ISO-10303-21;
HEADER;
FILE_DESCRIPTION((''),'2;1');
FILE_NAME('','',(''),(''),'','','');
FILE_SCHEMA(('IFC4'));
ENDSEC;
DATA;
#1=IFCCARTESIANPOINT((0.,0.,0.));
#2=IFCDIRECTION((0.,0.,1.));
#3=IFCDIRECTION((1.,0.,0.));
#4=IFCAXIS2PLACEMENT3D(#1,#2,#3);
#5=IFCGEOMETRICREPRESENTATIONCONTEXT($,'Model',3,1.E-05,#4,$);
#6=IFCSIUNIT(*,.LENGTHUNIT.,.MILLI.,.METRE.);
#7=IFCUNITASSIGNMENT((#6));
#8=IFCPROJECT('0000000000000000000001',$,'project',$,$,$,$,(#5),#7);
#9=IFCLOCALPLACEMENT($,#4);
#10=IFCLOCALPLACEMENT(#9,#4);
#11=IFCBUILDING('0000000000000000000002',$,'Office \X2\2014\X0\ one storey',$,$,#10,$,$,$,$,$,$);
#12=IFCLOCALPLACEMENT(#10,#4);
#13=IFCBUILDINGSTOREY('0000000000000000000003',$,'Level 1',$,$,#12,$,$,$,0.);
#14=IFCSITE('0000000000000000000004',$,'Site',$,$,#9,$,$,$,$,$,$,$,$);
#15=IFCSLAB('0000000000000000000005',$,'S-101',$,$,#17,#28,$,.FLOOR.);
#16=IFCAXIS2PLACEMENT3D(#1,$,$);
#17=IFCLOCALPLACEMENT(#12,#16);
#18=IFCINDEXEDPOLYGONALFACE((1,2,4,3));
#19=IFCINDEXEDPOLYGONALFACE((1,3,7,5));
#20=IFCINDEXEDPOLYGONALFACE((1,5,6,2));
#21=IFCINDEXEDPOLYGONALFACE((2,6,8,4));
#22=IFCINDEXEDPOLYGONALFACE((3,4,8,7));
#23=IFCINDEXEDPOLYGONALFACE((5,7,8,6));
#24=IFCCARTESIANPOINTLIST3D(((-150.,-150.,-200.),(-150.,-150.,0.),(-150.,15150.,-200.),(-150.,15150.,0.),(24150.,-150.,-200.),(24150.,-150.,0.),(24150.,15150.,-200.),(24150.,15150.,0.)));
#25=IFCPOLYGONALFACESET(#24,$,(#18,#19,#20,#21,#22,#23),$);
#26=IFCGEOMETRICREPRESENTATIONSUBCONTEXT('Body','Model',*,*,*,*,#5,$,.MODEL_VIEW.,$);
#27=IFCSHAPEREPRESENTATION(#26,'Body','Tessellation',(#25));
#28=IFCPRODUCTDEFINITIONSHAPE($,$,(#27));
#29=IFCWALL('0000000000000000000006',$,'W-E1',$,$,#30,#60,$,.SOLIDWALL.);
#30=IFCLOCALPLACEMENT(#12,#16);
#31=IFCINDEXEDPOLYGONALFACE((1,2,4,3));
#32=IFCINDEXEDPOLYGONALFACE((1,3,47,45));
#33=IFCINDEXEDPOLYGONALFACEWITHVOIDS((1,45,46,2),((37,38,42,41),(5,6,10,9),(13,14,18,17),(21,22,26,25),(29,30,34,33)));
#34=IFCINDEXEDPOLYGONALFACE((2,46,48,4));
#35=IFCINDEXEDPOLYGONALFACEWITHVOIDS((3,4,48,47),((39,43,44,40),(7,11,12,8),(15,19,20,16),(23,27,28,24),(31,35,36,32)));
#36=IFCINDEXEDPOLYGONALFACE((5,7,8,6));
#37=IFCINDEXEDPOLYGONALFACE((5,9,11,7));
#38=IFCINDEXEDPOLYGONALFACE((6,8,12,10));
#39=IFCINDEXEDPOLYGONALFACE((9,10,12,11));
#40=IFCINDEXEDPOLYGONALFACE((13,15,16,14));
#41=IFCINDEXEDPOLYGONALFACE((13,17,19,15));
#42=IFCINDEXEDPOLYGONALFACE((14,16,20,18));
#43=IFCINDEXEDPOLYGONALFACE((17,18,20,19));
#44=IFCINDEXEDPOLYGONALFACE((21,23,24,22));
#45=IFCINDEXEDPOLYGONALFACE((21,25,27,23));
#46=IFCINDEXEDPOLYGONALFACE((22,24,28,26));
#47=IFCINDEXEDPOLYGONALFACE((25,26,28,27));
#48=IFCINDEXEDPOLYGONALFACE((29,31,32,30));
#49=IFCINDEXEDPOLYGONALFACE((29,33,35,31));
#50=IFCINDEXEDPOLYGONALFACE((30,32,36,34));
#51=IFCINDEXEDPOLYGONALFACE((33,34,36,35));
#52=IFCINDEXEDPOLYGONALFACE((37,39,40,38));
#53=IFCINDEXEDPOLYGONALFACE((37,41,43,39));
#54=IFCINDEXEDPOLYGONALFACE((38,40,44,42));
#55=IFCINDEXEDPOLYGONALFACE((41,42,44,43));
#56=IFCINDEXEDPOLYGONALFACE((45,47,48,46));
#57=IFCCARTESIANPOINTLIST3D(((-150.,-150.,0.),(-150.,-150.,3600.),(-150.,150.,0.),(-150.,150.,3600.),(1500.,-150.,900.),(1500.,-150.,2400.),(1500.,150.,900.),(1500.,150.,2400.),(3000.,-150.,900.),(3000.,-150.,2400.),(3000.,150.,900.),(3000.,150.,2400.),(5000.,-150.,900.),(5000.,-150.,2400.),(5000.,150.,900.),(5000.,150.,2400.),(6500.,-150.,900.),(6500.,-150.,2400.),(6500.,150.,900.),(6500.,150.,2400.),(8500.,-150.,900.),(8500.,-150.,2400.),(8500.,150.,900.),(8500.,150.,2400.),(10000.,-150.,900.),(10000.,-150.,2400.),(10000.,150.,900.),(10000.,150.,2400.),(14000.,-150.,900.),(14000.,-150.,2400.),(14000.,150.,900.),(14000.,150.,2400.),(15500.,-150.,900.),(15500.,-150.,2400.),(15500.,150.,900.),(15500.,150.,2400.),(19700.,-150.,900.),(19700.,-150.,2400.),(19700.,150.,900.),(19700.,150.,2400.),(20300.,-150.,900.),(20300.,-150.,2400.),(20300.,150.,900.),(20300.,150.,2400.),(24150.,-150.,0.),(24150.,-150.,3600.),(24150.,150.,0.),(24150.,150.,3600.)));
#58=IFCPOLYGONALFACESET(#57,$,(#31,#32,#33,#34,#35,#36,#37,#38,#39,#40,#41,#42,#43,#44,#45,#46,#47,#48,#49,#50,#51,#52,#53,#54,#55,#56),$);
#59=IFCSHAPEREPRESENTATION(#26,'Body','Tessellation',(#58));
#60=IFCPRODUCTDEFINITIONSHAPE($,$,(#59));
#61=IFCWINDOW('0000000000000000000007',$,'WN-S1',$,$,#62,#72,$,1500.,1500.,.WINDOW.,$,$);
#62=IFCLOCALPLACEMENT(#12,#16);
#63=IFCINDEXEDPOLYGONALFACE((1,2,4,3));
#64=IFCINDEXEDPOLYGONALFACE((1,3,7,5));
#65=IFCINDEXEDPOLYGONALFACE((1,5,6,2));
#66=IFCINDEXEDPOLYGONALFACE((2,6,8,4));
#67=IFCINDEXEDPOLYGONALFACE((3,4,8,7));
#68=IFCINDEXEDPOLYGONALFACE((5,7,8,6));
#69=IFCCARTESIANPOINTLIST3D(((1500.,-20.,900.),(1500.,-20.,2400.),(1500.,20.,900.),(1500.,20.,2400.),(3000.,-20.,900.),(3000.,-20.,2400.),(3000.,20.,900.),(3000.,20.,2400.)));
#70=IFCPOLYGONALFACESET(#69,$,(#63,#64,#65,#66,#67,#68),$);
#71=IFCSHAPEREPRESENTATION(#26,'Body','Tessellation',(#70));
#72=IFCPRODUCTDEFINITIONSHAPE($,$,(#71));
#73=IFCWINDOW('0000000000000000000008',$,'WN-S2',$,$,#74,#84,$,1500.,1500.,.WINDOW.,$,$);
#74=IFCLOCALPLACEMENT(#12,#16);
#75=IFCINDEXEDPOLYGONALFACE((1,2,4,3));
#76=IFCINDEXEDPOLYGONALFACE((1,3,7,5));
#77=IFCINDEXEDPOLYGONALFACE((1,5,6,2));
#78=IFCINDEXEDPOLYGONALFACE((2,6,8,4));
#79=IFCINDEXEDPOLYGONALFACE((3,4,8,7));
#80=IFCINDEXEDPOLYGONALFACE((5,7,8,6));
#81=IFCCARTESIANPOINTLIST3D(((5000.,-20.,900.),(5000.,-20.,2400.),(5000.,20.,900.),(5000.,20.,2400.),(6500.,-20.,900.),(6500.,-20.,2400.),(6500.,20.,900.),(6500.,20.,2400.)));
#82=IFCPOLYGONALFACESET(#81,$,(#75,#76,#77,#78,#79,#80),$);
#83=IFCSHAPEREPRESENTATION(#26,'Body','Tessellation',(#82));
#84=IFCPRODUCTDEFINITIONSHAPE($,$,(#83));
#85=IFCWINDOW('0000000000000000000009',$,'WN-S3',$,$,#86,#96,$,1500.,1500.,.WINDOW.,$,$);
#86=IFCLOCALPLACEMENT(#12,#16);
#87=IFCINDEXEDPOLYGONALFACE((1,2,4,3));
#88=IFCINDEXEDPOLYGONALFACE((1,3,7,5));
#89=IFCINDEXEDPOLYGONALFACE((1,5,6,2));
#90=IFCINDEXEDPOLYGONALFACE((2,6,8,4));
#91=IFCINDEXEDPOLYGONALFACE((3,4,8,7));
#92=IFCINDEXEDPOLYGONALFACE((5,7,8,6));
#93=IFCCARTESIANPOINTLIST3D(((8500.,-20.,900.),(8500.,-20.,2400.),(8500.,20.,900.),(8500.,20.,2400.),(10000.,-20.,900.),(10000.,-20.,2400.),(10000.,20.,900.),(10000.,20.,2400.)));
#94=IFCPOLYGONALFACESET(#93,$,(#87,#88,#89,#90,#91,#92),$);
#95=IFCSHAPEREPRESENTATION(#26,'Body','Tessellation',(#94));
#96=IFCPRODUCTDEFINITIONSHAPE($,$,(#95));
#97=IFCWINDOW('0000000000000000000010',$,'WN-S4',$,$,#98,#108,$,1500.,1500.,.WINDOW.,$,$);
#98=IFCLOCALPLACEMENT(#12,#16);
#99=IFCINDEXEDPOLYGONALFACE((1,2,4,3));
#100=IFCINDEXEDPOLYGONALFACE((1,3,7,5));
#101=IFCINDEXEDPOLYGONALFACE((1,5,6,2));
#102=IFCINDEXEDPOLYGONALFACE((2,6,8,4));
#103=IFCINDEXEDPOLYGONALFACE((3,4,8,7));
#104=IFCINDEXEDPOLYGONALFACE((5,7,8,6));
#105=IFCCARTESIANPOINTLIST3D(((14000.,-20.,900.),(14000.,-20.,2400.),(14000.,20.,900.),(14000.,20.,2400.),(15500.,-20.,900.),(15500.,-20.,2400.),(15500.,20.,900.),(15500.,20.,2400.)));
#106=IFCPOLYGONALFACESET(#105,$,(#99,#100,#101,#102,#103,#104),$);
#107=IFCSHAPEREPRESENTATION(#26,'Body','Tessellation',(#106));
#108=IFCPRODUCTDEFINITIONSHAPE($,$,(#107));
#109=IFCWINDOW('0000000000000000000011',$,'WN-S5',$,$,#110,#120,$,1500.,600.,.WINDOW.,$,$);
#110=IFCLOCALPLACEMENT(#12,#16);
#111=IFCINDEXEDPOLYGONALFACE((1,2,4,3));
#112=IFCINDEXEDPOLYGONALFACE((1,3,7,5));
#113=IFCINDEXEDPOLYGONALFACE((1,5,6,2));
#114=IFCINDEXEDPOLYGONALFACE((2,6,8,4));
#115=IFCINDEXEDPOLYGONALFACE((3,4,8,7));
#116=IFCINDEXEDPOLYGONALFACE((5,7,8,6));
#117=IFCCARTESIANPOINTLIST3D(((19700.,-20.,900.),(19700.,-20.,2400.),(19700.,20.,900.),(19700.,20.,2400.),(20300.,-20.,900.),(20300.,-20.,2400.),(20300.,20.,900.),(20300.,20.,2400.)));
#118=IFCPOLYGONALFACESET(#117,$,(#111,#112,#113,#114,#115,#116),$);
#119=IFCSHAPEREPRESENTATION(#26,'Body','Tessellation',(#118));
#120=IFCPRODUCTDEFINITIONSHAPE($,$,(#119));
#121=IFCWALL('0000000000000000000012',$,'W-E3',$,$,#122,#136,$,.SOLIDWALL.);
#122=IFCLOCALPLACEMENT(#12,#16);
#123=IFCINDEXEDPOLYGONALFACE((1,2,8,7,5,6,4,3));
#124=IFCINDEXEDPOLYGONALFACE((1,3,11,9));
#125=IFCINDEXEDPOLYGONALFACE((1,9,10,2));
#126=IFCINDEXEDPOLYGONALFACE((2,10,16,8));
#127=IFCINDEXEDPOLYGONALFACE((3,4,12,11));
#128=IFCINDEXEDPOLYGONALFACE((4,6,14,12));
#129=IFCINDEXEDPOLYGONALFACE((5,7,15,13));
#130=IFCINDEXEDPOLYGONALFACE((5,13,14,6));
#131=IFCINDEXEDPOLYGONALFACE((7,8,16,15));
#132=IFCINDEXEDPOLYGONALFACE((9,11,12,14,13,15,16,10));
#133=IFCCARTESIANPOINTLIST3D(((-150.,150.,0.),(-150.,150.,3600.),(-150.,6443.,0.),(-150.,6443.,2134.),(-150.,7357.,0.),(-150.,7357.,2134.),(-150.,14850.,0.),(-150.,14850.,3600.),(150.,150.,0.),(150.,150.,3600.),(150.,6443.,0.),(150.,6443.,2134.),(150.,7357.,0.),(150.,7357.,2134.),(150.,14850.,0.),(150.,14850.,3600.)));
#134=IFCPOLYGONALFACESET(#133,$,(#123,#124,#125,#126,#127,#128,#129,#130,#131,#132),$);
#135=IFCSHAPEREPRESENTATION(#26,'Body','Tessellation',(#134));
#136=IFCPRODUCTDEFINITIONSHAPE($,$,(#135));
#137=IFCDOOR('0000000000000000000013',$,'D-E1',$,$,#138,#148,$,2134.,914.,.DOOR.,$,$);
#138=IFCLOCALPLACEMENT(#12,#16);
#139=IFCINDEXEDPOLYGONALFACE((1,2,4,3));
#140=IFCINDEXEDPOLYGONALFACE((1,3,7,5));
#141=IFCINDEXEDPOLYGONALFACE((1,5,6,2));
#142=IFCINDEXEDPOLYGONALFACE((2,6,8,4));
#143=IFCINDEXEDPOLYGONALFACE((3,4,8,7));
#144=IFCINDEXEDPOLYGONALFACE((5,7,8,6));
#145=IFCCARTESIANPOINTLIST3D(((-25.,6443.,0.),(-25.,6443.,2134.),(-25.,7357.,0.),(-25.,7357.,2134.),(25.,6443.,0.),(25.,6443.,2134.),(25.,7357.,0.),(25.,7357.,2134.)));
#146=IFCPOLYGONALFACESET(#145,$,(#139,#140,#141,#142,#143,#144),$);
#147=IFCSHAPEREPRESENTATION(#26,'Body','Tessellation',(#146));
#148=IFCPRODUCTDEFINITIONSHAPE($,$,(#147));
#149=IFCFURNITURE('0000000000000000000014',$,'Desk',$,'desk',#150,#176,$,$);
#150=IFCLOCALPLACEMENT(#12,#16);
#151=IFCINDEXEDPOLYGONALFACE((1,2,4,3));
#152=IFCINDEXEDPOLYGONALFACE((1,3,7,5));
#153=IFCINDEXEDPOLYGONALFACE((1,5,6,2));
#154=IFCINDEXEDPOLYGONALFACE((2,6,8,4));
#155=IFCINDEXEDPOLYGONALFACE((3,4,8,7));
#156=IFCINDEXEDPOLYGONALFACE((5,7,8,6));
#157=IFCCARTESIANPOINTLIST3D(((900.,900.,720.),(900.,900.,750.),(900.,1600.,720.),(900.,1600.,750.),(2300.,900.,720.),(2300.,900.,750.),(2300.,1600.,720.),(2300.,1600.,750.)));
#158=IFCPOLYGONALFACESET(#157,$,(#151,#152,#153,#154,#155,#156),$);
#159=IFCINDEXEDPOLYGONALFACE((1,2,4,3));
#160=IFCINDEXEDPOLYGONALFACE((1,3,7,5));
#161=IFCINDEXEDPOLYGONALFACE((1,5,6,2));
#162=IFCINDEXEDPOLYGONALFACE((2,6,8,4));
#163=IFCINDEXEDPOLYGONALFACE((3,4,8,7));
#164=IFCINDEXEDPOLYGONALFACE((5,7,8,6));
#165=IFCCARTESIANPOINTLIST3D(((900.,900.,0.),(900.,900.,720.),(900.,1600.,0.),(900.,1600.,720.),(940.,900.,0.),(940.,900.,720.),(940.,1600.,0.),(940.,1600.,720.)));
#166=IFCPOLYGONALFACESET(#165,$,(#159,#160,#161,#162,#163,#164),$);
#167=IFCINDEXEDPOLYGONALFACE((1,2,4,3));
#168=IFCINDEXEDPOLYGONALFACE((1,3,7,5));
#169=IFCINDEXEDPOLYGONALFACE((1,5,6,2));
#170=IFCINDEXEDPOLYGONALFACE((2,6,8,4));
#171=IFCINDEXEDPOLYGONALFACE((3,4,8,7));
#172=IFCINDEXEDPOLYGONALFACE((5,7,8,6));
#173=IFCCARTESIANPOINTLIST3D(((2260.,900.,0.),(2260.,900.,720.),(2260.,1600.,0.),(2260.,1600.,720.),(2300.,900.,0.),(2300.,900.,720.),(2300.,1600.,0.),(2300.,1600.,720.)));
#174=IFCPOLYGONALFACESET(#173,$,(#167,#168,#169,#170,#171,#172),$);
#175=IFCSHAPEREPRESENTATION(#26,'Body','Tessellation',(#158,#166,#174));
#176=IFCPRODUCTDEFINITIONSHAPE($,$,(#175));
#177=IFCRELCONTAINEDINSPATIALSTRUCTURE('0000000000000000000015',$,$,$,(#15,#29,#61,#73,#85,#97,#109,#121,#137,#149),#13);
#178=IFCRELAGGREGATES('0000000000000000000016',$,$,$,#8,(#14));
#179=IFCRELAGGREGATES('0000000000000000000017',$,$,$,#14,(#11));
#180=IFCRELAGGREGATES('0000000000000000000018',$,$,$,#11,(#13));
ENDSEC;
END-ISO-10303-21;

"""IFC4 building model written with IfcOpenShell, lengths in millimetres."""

from ifc_helpers import new_model, si_unit, frame, frame_2d, origin, origin_with_axes, place, context, subcontext, project, spatial, rectangle, extrude, element, fill, save


model = new_model("IFC4")

# Units and contexts
model_context = context("Model", 3, precision=1e-05, world=origin_with_axes())
body_context = subcontext(model_context, "Body", "Model", "MODEL_VIEW")
ifc_project = project(units=[si_unit("LENGTHUNIT", "METRE", prefix="MILLI")], contexts=[model_context])

# Site, building, storey
site_placement = place(None, origin_with_axes())
site = spatial("IfcSite", under=ifc_project, at=site_placement, Name="Site")
building_placement = place(site_placement, origin_with_axes())
building = spatial("IfcBuilding", under=site, at=building_placement, Name="Office — one storey")
storey_placement = place(building_placement, origin_with_axes())
storey = spatial("IfcBuildingStorey", under=building, at=storey_placement, Name="Level 1", Elevation=0.0)

# Slab
slab_placement = place(storey_placement, frame((-150.0, -150.0, -200.0), z_axis=(0.0, 0.0, 1.0), x_axis=(1.0, 0.0, 0.0)))
element("IfcSlab", 1, at=slab_placement, inside=storey, Name="S-101", PredefinedType="FLOOR", context=body_context, shape_type="SweptSolid", body=[
    extrude(rectangle(XDim=24300.0, YDim=15300.0, at=frame_2d((12150.0, 7650.0))), origin(), (0.0, 0.0, 1.0), 200.0),
])

# Wall, openings, windows
wall_1_placement = place(storey_placement, frame((0.0, -150.0, 0.0), z_axis=(0.0, 0.0, 1.0), x_axis=(1.0, 0.0, 0.0)))
wall_1 = element("IfcWall", 2, at=wall_1_placement, inside=storey, Name="W-E1", PredefinedType="SOLIDWALL", context=body_context, shape_type="SweptSolid", body=[
    extrude(rectangle(XDim=24300.0, YDim=300.0, at=frame_2d((12000.0, 150.0))), origin(), (0.0, 0.0, 1.0), 3600.0),
])
opening_1_placement = place(wall_1_placement, frame((1500.0, -10.0, 900.0), z_axis=(0.0, 0.0, 1.0), x_axis=(1.0, 0.0, 0.0)))
opening_1 = element("IfcOpeningElement", 3, at=opening_1_placement, cuts=wall_1, context=body_context, shape_type="SweptSolid", body=[
    extrude(rectangle(XDim=1500.0, YDim=320.0, at=frame_2d((750.0, 160.0))), origin(), (0.0, 0.0, 1.0), 1500.0),
])
opening_2_placement = place(wall_1_placement, frame((5000.0, -10.0, 900.0), z_axis=(0.0, 0.0, 1.0), x_axis=(1.0, 0.0, 0.0)))
opening_2 = element("IfcOpeningElement", 4, at=opening_2_placement, cuts=wall_1, context=body_context, shape_type="SweptSolid", body=[
    extrude(rectangle(XDim=1500.0, YDim=320.0, at=frame_2d((750.0, 160.0))), origin(), (0.0, 0.0, 1.0), 1500.0),
])
opening_3_placement = place(wall_1_placement, frame((8500.0, -10.0, 900.0), z_axis=(0.0, 0.0, 1.0), x_axis=(1.0, 0.0, 0.0)))
opening_3 = element("IfcOpeningElement", 5, at=opening_3_placement, cuts=wall_1, context=body_context, shape_type="SweptSolid", body=[
    extrude(rectangle(XDim=1500.0, YDim=320.0, at=frame_2d((750.0, 160.0))), origin(), (0.0, 0.0, 1.0), 1500.0),
])
opening_4_placement = place(wall_1_placement, frame((14000.0, -10.0, 900.0), z_axis=(0.0, 0.0, 1.0), x_axis=(1.0, 0.0, 0.0)))
opening_4 = element("IfcOpeningElement", 6, at=opening_4_placement, cuts=wall_1, context=body_context, shape_type="SweptSolid", body=[
    extrude(rectangle(XDim=1500.0, YDim=320.0, at=frame_2d((750.0, 160.0))), origin(), (0.0, 0.0, 1.0), 1500.0),
])
opening_5_placement = place(wall_1_placement, frame((19700.0, -10.0, 900.0), z_axis=(0.0, 0.0, 1.0), x_axis=(1.0, 0.0, 0.0)))
opening_5 = element("IfcOpeningElement", 7, at=opening_5_placement, cuts=wall_1, context=body_context, shape_type="SweptSolid", body=[
    extrude(rectangle(XDim=600.0, YDim=320.0, at=frame_2d((300.0, 160.0))), origin(), (0.0, 0.0, 1.0), 1500.0),
])
window_1_placement = place(storey_placement, frame((1500.0, -20.0, 900.0), z_axis=(0.0, 0.0, 1.0), x_axis=(1.0, 0.0, 0.0)))
window_1 = element("IfcWindow", 8, at=window_1_placement, inside=storey, Name="WN-S1", OverallHeight=1500.0, OverallWidth=1500.0, PredefinedType="WINDOW", context=body_context, shape_type="SweptSolid", body=[
    extrude(rectangle(XDim=1500.0, YDim=40.0, at=frame_2d((750.0, 20.0))), origin(), (0.0, 0.0, 1.0), 1500.0),
])
fill(opening_1, window_1)
window_2_placement = place(storey_placement, frame((5000.0, -20.0, 900.0), z_axis=(0.0, 0.0, 1.0), x_axis=(1.0, 0.0, 0.0)))
window_2 = element("IfcWindow", 9, at=window_2_placement, inside=storey, Name="WN-S2", OverallHeight=1500.0, OverallWidth=1500.0, PredefinedType="WINDOW", context=body_context, shape_type="SweptSolid", body=[
    extrude(rectangle(XDim=1500.0, YDim=40.0, at=frame_2d((750.0, 20.0))), origin(), (0.0, 0.0, 1.0), 1500.0),
])
fill(opening_2, window_2)
window_3_placement = place(storey_placement, frame((8500.0, -20.0, 900.0), z_axis=(0.0, 0.0, 1.0), x_axis=(1.0, 0.0, 0.0)))
window_3 = element("IfcWindow", 10, at=window_3_placement, inside=storey, Name="WN-S3", OverallHeight=1500.0, OverallWidth=1500.0, PredefinedType="WINDOW", context=body_context, shape_type="SweptSolid", body=[
    extrude(rectangle(XDim=1500.0, YDim=40.0, at=frame_2d((750.0, 20.0))), origin(), (0.0, 0.0, 1.0), 1500.0),
])
fill(opening_3, window_3)
window_4_placement = place(storey_placement, frame((14000.0, -20.0, 900.0), z_axis=(0.0, 0.0, 1.0), x_axis=(1.0, 0.0, 0.0)))
window_4 = element("IfcWindow", 11, at=window_4_placement, inside=storey, Name="WN-S4", OverallHeight=1500.0, OverallWidth=1500.0, PredefinedType="WINDOW", context=body_context, shape_type="SweptSolid", body=[
    extrude(rectangle(XDim=1500.0, YDim=40.0, at=frame_2d((750.0, 20.0))), origin(), (0.0, 0.0, 1.0), 1500.0),
])
fill(opening_4, window_4)
window_5_placement = place(storey_placement, frame((19700.0, -20.0, 900.0), z_axis=(0.0, 0.0, 1.0), x_axis=(1.0, 0.0, 0.0)))
window_5 = element("IfcWindow", 12, at=window_5_placement, inside=storey, Name="WN-S5", OverallHeight=1500.0, OverallWidth=600.0, PredefinedType="WINDOW", context=body_context, shape_type="SweptSolid", body=[
    extrude(rectangle(XDim=600.0, YDim=40.0, at=frame_2d((300.0, 20.0))), origin(), (0.0, 0.0, 1.0), 1500.0),
])
fill(opening_5, window_5)

# Wall, opening, door
wall_2_placement = place(storey_placement, frame((-150.0, 0.0, 0.0), z_axis=(0.0, 0.0, 1.0), x_axis=(1.0, 0.0, 0.0)))
wall_2 = element("IfcWall", 13, at=wall_2_placement, inside=storey, Name="W-E3", PredefinedType="SOLIDWALL", context=body_context, shape_type="SweptSolid", body=[
    extrude(rectangle(XDim=300.0, YDim=14700.0, at=frame_2d((150.0, 7500.0))), origin(), (0.0, 0.0, 1.0), 3600.0),
])
opening_6_placement = place(wall_2_placement, frame((-10.0, 6443.0, 0.0), z_axis=(0.0, 0.0, 1.0), x_axis=(1.0, 0.0, 0.0)))
opening_6 = element("IfcOpeningElement", 14, at=opening_6_placement, cuts=wall_2, context=body_context, shape_type="SweptSolid", body=[
    extrude(rectangle(XDim=320.0, YDim=914.0, at=frame_2d((160.0, 457.0))), origin(), (0.0, 0.0, 1.0), 2134.0),
])
door_placement = place(storey_placement, frame((-25.0, 6443.0, 0.0), z_axis=(0.0, 0.0, 1.0), x_axis=(1.0, 0.0, 0.0)))
door = element("IfcDoor", 15, at=door_placement, inside=storey, Name="D-E1", OverallHeight=2134.0, OverallWidth=914.0, PredefinedType="DOOR", context=body_context, shape_type="SweptSolid", body=[
    extrude(rectangle(XDim=50.0, YDim=914.0, at=frame_2d((25.0, 457.0))), origin(), (0.0, 0.0, 1.0), 2134.0),
])
fill(opening_6, door)

# Furniture
furniture_1_placement = place(storey_placement, frame((900.0, 900.0, 0.0), z_axis=(0.0, 0.0, 1.0), x_axis=(1.0, 0.0, 0.0)))
element("IfcFurniture", 16, at=furniture_1_placement, inside=storey, Name="Desk", ObjectType="desk", context=body_context, shape_type="SweptSolid", body=[
    extrude(rectangle(XDim=1400.0, YDim=700.0, at=frame_2d((700.0, 350.0))), frame((0.0, 0.0, 720.0)), (0.0, 0.0, 1.0), 30.0),
    extrude(rectangle(XDim=40.0, YDim=700.0, at=frame_2d((20.0, 350.0))), origin(), (0.0, 0.0, 1.0), 720.0),
    extrude(rectangle(XDim=40.0, YDim=700.0, at=frame_2d((1380.0, 350.0))), origin(), (0.0, 0.0, 1.0), 720.0),
])

save(model, "model.ifc")
